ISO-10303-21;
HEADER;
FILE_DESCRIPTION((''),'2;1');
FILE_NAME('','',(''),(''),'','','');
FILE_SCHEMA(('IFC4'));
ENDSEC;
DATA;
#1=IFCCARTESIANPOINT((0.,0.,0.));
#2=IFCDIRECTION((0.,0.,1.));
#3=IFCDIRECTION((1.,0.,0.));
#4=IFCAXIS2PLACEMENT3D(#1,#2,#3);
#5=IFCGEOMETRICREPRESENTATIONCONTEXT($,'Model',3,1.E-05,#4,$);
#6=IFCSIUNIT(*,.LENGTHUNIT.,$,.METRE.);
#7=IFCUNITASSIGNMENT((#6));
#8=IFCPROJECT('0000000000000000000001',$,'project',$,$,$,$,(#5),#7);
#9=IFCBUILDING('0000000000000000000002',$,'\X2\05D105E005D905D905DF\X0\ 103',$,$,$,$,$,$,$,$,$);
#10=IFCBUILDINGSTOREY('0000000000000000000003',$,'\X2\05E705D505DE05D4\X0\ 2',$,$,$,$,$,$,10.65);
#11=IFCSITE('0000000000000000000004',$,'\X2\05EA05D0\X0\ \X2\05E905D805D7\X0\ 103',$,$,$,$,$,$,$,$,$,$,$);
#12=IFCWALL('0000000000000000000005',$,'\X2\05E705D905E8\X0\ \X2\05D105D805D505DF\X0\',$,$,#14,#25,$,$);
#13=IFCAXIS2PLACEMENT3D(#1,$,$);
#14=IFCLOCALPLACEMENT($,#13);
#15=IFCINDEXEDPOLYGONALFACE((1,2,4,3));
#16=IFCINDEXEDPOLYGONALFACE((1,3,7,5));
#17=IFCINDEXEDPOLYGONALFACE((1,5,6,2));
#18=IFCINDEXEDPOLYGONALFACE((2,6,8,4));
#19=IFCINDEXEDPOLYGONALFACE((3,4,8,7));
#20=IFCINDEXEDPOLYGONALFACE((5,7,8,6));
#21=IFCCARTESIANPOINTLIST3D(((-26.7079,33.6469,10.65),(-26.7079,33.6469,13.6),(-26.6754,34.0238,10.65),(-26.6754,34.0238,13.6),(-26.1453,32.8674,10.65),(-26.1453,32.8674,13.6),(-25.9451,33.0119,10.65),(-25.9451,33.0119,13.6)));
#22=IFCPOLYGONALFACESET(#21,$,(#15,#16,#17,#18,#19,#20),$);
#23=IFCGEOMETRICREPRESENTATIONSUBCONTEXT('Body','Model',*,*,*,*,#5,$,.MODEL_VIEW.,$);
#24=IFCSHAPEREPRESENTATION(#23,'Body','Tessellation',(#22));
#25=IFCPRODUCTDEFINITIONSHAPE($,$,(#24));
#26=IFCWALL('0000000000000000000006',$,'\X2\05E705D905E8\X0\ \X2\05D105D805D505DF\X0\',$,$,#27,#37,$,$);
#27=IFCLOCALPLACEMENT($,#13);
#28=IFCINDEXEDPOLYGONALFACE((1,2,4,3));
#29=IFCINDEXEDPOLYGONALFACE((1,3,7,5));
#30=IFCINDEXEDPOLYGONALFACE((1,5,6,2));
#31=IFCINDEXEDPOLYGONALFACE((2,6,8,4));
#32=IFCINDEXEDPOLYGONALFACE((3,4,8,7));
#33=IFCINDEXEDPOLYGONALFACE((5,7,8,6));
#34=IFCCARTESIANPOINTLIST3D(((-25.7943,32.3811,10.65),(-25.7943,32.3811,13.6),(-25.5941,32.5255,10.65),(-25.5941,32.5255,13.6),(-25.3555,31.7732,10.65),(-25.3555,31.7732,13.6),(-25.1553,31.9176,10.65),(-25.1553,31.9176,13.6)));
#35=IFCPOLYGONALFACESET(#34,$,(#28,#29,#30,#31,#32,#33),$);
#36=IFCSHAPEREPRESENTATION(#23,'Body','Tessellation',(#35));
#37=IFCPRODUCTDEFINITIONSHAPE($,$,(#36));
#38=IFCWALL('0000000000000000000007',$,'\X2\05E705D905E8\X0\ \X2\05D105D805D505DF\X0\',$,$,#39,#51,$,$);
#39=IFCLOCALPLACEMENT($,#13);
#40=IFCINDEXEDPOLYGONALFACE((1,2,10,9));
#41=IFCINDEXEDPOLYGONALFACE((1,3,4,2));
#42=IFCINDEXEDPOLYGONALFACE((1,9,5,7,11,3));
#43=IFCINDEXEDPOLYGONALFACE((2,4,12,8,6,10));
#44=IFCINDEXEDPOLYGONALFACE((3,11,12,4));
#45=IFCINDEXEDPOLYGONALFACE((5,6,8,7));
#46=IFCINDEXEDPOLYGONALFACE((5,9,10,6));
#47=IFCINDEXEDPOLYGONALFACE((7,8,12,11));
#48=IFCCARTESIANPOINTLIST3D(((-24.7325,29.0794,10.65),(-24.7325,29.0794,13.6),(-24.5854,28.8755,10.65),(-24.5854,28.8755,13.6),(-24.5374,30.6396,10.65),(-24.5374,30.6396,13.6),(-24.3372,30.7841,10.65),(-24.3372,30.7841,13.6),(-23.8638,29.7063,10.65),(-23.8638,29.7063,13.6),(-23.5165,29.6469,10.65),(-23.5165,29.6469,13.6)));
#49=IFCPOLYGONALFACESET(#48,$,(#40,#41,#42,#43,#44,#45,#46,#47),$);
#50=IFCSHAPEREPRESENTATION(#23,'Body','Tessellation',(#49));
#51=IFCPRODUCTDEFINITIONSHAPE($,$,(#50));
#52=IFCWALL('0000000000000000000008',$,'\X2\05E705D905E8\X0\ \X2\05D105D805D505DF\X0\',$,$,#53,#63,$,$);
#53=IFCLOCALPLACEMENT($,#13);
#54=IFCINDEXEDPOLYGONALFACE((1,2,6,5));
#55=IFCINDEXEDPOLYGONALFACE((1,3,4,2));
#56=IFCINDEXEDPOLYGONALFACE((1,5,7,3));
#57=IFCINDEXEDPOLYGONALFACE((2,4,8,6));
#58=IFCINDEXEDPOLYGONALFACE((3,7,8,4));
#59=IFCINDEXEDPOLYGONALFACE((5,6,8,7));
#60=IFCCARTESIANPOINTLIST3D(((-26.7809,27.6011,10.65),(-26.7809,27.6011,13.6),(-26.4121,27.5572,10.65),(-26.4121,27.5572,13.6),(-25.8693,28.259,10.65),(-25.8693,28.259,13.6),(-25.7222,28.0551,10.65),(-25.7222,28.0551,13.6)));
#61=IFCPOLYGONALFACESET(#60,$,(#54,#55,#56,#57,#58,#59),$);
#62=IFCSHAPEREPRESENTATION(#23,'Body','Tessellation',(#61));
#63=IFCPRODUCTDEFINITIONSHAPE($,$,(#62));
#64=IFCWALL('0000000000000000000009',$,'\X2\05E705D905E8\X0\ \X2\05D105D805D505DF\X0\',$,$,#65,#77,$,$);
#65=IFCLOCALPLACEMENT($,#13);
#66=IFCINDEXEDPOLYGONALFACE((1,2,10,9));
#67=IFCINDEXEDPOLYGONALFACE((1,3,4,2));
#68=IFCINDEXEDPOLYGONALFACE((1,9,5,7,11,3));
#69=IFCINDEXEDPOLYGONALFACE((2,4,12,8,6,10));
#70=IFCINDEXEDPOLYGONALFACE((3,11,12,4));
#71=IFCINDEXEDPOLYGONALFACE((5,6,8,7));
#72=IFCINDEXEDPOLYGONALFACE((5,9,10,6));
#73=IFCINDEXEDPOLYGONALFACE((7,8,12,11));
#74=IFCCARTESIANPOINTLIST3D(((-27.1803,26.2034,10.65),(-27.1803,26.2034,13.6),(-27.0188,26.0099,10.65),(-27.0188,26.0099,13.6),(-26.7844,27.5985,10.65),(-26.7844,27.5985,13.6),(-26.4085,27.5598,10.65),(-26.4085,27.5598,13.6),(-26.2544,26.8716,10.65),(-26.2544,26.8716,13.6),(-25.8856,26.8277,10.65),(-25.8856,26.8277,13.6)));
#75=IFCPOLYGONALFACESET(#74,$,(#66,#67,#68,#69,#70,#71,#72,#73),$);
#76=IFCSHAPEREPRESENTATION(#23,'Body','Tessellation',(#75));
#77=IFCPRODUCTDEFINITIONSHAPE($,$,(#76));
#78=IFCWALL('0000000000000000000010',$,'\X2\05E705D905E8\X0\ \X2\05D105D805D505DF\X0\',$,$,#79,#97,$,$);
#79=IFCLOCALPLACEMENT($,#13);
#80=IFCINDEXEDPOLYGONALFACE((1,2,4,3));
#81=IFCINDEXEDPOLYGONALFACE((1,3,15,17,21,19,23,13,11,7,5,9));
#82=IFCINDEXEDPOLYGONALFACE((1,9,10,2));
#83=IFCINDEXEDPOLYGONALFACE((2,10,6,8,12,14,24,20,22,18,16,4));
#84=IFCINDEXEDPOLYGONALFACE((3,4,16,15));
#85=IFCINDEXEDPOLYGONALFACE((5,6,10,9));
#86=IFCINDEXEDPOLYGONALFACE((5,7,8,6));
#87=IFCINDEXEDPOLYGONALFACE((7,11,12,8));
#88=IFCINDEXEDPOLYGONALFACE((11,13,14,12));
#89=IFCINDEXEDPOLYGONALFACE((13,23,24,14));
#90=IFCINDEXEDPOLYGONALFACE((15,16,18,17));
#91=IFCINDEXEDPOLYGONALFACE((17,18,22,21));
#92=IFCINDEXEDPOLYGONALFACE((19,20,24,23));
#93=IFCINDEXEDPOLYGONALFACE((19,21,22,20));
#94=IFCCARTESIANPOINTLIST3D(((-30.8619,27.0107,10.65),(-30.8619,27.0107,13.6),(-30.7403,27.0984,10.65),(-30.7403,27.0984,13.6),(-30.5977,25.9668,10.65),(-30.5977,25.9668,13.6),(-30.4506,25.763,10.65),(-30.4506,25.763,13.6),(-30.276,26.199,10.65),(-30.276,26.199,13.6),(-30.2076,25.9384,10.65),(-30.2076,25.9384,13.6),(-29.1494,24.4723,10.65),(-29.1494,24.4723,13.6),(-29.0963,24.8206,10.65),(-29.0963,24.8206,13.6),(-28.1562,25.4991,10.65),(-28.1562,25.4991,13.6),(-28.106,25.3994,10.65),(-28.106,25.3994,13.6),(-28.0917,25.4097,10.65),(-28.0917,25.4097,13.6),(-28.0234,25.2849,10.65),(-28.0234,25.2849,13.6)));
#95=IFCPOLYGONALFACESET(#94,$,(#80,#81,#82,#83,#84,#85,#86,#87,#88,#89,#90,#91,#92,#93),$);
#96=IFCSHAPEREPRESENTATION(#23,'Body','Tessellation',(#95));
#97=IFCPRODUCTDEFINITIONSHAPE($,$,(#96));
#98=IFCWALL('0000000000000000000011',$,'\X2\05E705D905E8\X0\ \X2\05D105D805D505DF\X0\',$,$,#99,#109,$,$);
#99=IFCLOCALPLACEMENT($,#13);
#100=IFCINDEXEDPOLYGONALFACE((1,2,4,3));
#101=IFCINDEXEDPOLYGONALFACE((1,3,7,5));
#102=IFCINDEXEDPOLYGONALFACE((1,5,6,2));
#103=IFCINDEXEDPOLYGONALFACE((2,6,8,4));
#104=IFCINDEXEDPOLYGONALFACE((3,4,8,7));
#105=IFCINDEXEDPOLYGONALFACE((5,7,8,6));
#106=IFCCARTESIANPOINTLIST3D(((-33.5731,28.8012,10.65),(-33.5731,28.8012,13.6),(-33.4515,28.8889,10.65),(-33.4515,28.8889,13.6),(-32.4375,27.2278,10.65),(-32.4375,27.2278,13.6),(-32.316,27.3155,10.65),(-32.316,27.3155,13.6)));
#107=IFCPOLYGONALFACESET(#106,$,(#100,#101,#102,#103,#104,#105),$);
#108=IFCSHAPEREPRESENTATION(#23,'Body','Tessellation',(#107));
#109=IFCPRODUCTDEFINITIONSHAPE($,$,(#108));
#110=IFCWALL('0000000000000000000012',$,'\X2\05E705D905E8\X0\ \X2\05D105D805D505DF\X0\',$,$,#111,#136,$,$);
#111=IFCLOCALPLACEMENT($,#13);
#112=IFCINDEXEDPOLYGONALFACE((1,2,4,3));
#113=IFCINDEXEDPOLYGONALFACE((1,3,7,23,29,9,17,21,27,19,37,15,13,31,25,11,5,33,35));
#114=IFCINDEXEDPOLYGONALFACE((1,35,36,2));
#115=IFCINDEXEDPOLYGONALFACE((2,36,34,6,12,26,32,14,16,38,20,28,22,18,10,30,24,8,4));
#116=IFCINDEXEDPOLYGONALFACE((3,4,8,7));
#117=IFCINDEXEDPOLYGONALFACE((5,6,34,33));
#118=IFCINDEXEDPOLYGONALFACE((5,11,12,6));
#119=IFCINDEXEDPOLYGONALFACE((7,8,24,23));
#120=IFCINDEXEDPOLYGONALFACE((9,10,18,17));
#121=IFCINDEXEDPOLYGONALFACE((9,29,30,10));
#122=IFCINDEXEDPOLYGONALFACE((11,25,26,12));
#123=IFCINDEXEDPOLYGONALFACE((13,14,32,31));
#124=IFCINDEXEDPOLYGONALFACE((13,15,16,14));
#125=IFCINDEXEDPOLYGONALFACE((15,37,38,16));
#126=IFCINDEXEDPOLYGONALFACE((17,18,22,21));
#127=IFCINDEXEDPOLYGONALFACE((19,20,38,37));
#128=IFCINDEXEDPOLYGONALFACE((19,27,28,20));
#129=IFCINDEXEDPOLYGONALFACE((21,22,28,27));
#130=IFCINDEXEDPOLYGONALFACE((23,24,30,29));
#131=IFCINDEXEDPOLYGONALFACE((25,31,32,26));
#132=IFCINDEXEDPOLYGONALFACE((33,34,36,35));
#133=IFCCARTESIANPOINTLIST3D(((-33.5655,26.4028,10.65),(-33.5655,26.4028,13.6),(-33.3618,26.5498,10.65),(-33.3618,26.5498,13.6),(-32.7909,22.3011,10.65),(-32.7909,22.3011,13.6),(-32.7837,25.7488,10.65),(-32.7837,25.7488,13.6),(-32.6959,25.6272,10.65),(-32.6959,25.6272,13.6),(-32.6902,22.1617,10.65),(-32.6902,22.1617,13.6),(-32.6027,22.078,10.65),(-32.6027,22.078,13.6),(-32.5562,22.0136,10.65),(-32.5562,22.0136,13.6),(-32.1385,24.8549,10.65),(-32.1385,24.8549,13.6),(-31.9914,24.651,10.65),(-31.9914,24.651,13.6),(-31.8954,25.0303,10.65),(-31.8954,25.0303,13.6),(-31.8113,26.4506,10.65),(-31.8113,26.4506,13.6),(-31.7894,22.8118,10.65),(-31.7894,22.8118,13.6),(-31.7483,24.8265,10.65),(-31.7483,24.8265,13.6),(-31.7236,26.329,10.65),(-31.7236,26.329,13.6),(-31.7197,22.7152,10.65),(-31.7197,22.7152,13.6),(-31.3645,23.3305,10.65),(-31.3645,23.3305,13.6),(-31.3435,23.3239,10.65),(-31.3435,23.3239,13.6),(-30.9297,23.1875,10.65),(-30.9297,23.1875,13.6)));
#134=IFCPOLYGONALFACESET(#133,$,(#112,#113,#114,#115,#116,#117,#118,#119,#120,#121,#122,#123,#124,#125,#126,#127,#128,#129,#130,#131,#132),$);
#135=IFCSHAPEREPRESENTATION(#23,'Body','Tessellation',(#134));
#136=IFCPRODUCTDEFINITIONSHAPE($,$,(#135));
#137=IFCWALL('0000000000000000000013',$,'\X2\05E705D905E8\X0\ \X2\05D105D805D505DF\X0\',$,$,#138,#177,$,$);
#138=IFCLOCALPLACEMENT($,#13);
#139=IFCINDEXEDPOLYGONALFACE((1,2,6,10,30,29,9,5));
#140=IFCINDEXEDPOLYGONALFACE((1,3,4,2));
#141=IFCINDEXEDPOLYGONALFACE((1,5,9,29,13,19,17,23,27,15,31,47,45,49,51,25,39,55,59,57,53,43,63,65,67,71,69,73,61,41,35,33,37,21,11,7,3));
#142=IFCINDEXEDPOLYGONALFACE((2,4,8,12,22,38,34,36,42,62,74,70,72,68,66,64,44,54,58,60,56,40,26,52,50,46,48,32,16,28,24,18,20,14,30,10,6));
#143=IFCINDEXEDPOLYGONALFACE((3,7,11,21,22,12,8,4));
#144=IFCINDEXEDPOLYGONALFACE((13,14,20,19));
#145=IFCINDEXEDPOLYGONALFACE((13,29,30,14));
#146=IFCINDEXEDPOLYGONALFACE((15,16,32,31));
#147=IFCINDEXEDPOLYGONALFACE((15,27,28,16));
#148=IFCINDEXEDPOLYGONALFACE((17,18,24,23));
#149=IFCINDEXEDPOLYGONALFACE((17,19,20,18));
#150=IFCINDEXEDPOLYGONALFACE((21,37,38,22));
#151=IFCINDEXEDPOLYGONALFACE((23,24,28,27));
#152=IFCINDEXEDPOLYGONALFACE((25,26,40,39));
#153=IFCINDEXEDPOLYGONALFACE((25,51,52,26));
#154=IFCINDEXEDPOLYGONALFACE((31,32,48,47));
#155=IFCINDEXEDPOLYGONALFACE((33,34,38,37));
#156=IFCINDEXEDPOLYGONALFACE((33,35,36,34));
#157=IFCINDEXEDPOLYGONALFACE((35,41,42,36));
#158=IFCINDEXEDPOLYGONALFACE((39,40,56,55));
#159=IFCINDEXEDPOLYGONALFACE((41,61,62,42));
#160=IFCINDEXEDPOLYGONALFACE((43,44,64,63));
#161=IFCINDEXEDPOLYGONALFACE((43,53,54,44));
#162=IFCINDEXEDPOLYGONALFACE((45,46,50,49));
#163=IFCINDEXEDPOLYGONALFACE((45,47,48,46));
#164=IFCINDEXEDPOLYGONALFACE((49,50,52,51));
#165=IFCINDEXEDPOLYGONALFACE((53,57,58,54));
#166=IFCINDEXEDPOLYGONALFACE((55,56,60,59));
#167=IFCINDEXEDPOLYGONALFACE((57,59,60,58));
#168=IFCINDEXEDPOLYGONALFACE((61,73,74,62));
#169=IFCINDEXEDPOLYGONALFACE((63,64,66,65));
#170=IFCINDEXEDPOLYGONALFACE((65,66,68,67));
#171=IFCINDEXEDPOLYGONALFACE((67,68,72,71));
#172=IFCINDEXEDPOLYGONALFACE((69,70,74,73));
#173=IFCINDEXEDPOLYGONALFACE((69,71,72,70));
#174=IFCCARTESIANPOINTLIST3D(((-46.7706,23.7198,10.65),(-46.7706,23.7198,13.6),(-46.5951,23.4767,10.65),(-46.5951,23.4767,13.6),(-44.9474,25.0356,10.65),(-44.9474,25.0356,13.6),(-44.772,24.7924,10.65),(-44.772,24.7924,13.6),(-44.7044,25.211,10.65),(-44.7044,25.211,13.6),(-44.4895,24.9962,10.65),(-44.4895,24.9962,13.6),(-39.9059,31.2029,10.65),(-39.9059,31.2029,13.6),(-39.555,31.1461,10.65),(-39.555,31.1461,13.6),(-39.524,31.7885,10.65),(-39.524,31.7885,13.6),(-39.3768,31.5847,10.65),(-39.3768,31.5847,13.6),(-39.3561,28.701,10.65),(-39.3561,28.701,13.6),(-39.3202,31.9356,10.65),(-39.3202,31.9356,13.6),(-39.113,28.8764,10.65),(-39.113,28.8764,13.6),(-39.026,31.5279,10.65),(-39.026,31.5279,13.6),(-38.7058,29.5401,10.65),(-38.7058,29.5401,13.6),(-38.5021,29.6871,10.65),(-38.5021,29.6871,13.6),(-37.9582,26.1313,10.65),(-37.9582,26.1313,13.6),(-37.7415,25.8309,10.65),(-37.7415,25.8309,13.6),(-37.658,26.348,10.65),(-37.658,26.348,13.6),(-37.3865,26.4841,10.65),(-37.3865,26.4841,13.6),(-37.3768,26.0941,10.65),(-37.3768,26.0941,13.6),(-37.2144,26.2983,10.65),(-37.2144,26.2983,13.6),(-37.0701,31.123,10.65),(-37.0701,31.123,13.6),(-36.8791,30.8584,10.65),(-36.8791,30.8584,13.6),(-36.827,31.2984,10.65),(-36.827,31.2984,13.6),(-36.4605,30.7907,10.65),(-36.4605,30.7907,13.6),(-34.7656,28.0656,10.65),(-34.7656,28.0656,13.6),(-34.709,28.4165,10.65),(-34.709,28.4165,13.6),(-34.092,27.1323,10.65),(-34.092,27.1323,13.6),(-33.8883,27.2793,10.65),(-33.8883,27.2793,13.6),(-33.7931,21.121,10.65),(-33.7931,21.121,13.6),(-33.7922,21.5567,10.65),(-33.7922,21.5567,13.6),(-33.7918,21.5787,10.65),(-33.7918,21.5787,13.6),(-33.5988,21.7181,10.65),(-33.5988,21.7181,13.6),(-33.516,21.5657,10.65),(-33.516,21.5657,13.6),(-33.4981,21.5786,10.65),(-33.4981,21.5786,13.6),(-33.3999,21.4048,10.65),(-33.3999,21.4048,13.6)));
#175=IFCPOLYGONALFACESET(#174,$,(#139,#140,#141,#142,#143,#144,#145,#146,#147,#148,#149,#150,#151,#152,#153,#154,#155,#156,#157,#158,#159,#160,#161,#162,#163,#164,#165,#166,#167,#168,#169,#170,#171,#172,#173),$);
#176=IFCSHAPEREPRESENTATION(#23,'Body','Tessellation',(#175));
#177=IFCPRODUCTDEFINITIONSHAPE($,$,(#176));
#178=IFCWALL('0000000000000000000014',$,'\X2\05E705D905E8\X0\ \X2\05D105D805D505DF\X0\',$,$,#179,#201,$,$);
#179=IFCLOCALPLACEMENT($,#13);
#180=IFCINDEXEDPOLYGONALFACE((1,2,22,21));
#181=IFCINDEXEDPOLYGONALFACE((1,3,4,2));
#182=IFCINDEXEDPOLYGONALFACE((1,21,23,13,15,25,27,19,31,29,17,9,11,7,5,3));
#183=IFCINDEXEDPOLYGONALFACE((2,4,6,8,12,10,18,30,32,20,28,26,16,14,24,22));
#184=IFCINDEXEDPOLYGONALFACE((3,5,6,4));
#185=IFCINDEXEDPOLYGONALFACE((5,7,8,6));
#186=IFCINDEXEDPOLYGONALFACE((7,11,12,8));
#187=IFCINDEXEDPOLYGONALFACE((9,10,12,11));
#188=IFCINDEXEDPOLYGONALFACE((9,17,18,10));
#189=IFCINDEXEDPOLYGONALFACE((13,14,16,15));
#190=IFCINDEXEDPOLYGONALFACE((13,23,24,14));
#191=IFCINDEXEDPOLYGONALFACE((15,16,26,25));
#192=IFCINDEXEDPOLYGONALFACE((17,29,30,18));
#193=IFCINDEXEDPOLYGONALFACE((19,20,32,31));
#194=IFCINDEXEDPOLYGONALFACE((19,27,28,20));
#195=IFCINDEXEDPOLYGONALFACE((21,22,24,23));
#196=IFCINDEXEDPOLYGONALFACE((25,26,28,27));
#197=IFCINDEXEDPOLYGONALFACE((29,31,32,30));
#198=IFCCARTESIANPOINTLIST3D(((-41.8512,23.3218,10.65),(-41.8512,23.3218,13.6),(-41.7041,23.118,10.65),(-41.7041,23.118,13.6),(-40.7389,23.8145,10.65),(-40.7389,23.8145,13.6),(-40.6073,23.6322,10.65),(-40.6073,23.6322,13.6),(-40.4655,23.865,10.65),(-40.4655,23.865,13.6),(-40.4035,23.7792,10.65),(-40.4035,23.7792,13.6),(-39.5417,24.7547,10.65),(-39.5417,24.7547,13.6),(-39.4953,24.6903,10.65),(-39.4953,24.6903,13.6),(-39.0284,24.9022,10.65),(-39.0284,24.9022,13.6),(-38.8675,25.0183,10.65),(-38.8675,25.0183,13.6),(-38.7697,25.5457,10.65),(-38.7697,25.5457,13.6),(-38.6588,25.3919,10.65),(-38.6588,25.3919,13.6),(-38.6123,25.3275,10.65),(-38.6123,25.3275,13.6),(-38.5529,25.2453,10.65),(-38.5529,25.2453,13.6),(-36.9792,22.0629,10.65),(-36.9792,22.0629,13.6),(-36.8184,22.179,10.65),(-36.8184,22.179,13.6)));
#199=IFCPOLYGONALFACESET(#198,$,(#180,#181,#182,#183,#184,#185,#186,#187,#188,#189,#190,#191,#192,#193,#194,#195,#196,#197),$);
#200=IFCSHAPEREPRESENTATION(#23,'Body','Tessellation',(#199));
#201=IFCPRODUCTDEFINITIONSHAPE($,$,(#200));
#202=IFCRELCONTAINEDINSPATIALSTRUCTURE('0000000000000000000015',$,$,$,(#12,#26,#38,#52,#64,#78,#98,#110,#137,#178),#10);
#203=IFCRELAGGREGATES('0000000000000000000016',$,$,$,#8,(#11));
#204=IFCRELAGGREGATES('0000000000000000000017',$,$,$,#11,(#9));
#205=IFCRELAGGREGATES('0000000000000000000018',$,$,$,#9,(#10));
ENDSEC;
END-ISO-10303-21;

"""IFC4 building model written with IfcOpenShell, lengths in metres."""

from ifc_helpers import new_model, si_unit, frame, origin_with_axes, context, subcontext, project, spatial, polyline, outline, extrude, element, save


model = new_model("IFC4")

# Units and contexts
model_context = context("Model", 3, precision=1e-05, world=origin_with_axes())
body_context = subcontext(model_context, "Body", "Model", "MODEL_VIEW")
ifc_project = project(units=[si_unit("LENGTHUNIT", "METRE")], contexts=[model_context])

# Site, building, storey
site = spatial("IfcSite", under=ifc_project, Name="תא שטח 103")
building = spatial("IfcBuilding", under=site, Name="בניין 103")
storey = spatial("IfcBuildingStorey", under=building, Name="קומה 2", Elevation=10.65)

# Walls
element("IfcWall", 1, inside=storey, Name="קיר בטון", context=body_context, shape_type="SweptSolid", body=[
    extrude(outline(polyline([(-26.7079, 33.6469), (-26.6754, 34.0238), (-25.9451, 33.0119), (-26.1453, 32.8674), (-26.7079, 33.6469)])), frame((0.0, 0.0, 10.65)), (0.0, 0.0, 1.0), 2.95),
])
element("IfcWall", 2, inside=storey, Name="קיר בטון", context=body_context, shape_type="SweptSolid", body=[
    extrude(outline(polyline([(-25.5941, 32.5255), (-25.1553, 31.9176), (-25.3555, 31.7732), (-25.7943, 32.3811), (-25.5941, 32.5255)])), frame((0.0, 0.0, 10.65)), (0.0, 0.0, 1.0), 2.95),
])
element("IfcWall", 3, inside=storey, Name="קיר בטון", context=body_context, shape_type="SweptSolid", body=[
    extrude(outline(polyline([(-24.5374, 30.6396), (-24.3372, 30.7841), (-23.5165, 29.6469), (-24.5854, 28.8755), (-24.7325, 29.0794), (-23.8638, 29.7063), (-24.5374, 30.6396)])), frame((0.0, 0.0, 10.65)), (0.0, 0.0, 1.0), 2.95),
])
element("IfcWall", 4, inside=storey, Name="קיר בטון", context=body_context, shape_type="SweptSolid", body=[
    extrude(outline(polyline([(-26.4121, 27.5572), (-26.7809, 27.6011), (-25.8693, 28.259), (-25.7222, 28.0551), (-26.4121, 27.5572)])), frame((0.0, 0.0, 10.65)), (0.0, 0.0, 1.0), 2.95),
])
element("IfcWall", 5, inside=storey, Name="קיר בטון", context=body_context, shape_type="SweptSolid", body=[
    extrude(outline(polyline([(-27.0188, 26.0099), (-27.1803, 26.2034), (-26.2544, 26.8716), (-26.7844, 27.5985), (-26.4085, 27.5598), (-25.8856, 26.8277), (-27.0188, 26.0099)])), frame((0.0, 0.0, 10.65)), (0.0, 0.0, 1.0), 2.95),
])
element("IfcWall", 6, inside=storey, Name="קיר בטון", context=body_context, shape_type="SweptSolid", body=[
    extrude(outline(polyline([(-29.1494, 24.4723), (-30.2076, 25.9384), (-30.4506, 25.763), (-30.5977, 25.9668), (-30.276, 26.199), (-30.8619, 27.0107), (-30.7403, 27.0984), (-29.0963, 24.8206), (-28.1562, 25.4991), (-28.0917, 25.4097), (-28.106, 25.3994), (-28.0234, 25.2849), (-29.1494, 24.4723)])), frame((0.0, 0.0, 10.65)), (0.0, 0.0, 1.0), 2.95),
])
element("IfcWall", 7, inside=storey, Name="קיר בטון", context=body_context, shape_type="SweptSolid", body=[
    extrude(outline(polyline([(-32.4375, 27.2278), (-33.5731, 28.8012), (-33.4515, 28.8889), (-32.316, 27.3155), (-32.4375, 27.2278)])), frame((0.0, 0.0, 10.65)), (0.0, 0.0, 1.0), 2.95),
])
element("IfcWall", 8, inside=storey, Name="קיר בטון", context=body_context, shape_type="SweptSolid", body=[
    extrude(outline(polyline([(-31.9914, 24.651), (-30.9297, 23.1875), (-32.5562, 22.0136), (-32.6027, 22.078), (-31.7197, 22.7152), (-31.7894, 22.8118), (-32.6902, 22.1617), (-32.7909, 22.3011), (-31.3645, 23.3305), (-31.3435, 23.3239), (-33.5655, 26.4028), (-33.3618, 26.5498), (-32.7837, 25.7488), (-31.8113, 26.4506), (-31.7236, 26.329), (-32.6959, 25.6272), (-32.1385, 24.8549), (-31.8954, 25.0303), (-31.7483, 24.8265), (-31.9914, 24.651)])), frame((0.0, 0.0, 10.65)), (0.0, 0.0, 1.0), 2.95),
])
element("IfcWall", 9, inside=storey, Name="קיר בטון", context=body_context, shape_type="SweptSolid", body=[
    extrude(outline(polyline([(-37.2144, 26.2983), (-33.7922, 21.5567), (-33.7918, 21.5787), (-33.5988, 21.7181), (-33.4981, 21.5786), (-33.516, 21.5657), (-33.3999, 21.4048), (-33.7931, 21.121), (-37.3768, 26.0941), (-37.7415, 25.8309), (-37.9582, 26.1313), (-37.658, 26.348), (-39.3561, 28.701), (-44.4895, 24.9962), (-44.772, 24.7924), (-46.5951, 23.4767), (-46.7706, 23.7198), (-44.9474, 25.0356), (-44.7044, 25.211), (-38.7058, 29.5401), (-39.9059, 31.2029), (-39.3768, 31.5847), (-39.524, 31.7885), (-39.3202, 31.9356), (-39.026, 31.5279), (-39.555, 31.1461), (-38.5021, 29.6871), (-36.8791, 30.8584), (-37.0701, 31.123), (-36.827, 31.2984), (-36.4605, 30.7907), (-39.113, 28.8764), (-37.3865, 26.4841), (-34.709, 28.4165), (-33.8883, 27.2793), (-34.092, 27.1323), (-34.7656, 28.0656), (-37.2144, 26.2983)])), frame((0.0, 0.0, 10.65)), (0.0, 0.0, 1.0), 2.95),
])
element("IfcWall", 10, inside=storey, Name="קיר בטון", context=body_context, shape_type="SweptSolid", body=[
    extrude(outline(polyline([(-36.9792, 22.0629), (-39.0284, 24.9022), (-40.4655, 23.865), (-40.4035, 23.7792), (-40.6073, 23.6322), (-40.7389, 23.8145), (-41.7041, 23.118), (-41.8512, 23.3218), (-38.7697, 25.5457), (-38.6588, 25.3919), (-39.5417, 24.7547), (-39.4953, 24.6903), (-38.6123, 25.3275), (-38.5529, 25.2453), (-38.8675, 25.0183), (-36.8184, 22.179), (-36.9792, 22.0629)])), frame((0.0, 0.0, 10.65)), (0.0, 0.0, 1.0), 2.95),
])

save(model, "model.ifc")
